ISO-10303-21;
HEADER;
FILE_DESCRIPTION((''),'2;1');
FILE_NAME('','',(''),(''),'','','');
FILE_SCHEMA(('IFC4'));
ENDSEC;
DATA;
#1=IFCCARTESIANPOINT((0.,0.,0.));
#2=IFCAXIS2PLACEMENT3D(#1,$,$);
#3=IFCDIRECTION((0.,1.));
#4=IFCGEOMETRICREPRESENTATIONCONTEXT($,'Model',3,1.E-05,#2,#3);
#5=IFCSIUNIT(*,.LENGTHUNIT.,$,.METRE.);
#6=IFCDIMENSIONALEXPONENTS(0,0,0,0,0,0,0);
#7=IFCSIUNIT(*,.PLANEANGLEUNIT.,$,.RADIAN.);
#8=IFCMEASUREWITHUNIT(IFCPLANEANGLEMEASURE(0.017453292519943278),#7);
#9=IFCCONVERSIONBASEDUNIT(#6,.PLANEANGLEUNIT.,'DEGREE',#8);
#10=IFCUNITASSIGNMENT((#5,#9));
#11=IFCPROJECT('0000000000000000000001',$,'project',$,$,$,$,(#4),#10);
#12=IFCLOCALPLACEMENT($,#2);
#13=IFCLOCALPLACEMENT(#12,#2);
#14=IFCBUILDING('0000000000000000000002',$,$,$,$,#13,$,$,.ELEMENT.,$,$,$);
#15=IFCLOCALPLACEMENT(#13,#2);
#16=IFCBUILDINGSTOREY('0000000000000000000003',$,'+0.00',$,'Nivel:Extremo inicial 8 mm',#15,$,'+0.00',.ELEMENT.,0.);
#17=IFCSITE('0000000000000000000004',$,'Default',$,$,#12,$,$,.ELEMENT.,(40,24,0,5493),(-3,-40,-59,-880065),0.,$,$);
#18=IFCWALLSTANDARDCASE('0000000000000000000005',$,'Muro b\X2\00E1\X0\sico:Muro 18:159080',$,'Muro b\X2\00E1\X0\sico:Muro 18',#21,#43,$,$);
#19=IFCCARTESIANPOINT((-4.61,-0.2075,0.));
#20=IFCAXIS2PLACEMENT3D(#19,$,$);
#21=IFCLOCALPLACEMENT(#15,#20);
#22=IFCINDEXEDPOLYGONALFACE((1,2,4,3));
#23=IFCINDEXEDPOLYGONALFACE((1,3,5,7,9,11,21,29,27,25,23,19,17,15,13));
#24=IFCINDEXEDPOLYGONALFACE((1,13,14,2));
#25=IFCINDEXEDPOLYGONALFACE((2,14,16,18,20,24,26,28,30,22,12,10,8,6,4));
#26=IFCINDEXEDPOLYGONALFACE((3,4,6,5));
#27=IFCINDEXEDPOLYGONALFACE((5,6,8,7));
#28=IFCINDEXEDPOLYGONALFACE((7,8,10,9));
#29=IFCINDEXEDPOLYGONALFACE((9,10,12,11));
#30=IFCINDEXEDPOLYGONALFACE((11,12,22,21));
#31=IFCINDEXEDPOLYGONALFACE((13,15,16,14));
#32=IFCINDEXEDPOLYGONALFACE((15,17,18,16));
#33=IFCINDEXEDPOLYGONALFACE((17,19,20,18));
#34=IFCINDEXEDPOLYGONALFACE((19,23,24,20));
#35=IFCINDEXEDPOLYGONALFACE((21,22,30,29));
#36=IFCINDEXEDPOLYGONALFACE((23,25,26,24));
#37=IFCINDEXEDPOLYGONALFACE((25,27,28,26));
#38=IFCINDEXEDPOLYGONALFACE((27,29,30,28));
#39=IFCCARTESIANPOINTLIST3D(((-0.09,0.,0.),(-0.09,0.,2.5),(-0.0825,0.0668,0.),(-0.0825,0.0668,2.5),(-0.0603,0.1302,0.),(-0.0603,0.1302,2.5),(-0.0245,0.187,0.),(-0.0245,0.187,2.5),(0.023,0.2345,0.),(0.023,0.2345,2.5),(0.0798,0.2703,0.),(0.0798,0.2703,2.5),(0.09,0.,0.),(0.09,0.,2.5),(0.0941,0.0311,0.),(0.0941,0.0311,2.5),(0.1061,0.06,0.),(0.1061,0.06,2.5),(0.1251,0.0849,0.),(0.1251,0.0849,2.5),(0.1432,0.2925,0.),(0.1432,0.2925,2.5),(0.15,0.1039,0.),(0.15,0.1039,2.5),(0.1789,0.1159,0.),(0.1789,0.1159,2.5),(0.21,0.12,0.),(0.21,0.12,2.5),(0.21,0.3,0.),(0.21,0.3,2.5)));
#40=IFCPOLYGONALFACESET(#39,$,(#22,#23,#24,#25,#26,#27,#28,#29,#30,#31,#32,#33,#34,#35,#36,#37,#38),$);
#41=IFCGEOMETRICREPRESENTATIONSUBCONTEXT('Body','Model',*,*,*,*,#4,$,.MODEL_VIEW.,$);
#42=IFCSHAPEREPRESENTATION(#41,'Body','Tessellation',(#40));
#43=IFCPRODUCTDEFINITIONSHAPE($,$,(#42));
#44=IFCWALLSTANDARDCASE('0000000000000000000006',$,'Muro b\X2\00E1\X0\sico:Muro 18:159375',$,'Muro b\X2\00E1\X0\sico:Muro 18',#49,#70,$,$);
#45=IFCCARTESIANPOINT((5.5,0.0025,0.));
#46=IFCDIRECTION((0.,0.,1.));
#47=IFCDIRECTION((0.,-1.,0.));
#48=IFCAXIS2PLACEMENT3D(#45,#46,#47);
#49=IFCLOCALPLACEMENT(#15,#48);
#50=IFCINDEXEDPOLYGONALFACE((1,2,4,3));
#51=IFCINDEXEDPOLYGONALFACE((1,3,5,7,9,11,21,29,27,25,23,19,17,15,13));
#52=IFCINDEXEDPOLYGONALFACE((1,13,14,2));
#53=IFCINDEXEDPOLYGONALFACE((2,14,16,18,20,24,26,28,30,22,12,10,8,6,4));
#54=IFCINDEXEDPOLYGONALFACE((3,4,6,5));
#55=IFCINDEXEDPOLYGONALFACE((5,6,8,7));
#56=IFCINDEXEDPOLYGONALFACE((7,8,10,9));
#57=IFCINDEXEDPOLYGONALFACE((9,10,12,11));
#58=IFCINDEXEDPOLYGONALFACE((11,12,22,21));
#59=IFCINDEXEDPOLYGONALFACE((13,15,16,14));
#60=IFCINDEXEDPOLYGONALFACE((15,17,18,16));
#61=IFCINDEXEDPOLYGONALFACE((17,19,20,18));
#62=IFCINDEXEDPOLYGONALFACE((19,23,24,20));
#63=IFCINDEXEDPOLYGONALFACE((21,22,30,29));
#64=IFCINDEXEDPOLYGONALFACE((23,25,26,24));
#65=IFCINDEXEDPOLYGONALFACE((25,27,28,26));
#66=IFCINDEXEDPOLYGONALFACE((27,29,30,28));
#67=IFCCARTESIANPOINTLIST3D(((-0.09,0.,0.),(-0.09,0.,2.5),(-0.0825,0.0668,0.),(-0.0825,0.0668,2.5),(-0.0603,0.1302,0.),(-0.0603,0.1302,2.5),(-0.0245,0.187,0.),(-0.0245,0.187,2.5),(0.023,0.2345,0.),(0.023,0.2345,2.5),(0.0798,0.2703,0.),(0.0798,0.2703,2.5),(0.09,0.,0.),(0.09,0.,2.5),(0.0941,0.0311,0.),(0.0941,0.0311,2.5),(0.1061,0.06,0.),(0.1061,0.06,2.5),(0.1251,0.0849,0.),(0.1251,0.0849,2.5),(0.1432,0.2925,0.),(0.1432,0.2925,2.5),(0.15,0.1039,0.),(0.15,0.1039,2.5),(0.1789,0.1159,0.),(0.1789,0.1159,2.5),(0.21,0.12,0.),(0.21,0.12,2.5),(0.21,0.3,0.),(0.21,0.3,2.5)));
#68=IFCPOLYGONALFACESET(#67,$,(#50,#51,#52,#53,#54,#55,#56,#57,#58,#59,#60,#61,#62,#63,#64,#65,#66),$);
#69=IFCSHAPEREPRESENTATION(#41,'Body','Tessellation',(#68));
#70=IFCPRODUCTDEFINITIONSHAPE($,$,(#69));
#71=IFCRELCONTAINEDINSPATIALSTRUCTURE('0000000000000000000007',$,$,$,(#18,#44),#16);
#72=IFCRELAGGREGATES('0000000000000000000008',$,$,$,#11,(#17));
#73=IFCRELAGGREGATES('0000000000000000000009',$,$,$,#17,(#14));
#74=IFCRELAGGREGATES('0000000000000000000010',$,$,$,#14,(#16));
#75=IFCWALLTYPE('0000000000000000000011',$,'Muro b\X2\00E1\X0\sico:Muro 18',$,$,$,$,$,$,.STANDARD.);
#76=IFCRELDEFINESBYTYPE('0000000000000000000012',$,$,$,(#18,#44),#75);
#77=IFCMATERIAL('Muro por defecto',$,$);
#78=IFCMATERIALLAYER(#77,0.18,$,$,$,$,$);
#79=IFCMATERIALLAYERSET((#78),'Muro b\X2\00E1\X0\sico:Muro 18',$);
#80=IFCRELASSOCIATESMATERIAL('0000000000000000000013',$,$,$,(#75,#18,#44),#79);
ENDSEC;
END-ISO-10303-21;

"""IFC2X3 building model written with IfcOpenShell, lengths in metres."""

from ifc_helpers import new_model, entity, si_unit, converted_unit, direction, frame, frame_2d, origin, place, context, subcontext, project, spatial, polyline, circle_curve, parameter, trimmed, segment, composite_curve, outline, extrude, material, layer, layer_set, layer_usage, type_object, element, save


model = new_model("IFC2X3")

# Units and contexts
model_context = context("Model", 3, precision=1e-05, world=origin(), true_north=direction((0.0, 1.0)))
body_context = subcontext(model_context, "Body", "Model", "MODEL_VIEW")
ifc_project = project(units=[si_unit("LENGTHUNIT", "METRE"), converted_unit("PLANEANGLEUNIT", "DEGREE", entity("IfcPlaneAngleMeasure", 0.017453292519943278), si_unit("PLANEANGLEUNIT", "RADIAN"), dimensions=[0, 0, 0, 0, 0, 0, 0])], contexts=[model_context])

# Site, building, storey
site_placement = place(None, origin())
site = spatial("IfcSite", under=ifc_project, at=site_placement, Name="Default", CompositionType="ELEMENT", RefLatitude=(40, 24, 0, 5493), RefLongitude=(-3, -40, -59, -880065), RefElevation=0.0)
building_placement = place(site_placement, origin())
building = spatial("IfcBuilding", under=site, at=building_placement, CompositionType="ELEMENT")
storey_placement = place(building_placement, origin())
storey = spatial("IfcBuildingStorey", under=building, at=storey_placement, Name="+0.00", ObjectType="Nivel:Extremo inicial 8 mm", LongName="+0.00", CompositionType="ELEMENT", Elevation=0.0)

# Shared definitions
ifc_material_1 = material(Name="Muro por defecto")
ifc_layer = layer(ifc_material_1, 0.18)
ifc_layer_set = layer_set([ifc_layer], Name="Muro básico:Muro 18")
wall_type = type_object("IfcWallType", Name="Muro básico:Muro 18", PredefinedType="STANDARD", material=ifc_layer_set)

# Walls
ifc_layer_usage_1 = layer_usage(ifc_layer_set, "AXIS2", "POSITIVE", -0.09)
wall_1_placement = place(storey_placement, frame((-4.61, -0.2075, 0.0)))
element("IfcWallStandardCase", 1, at=wall_1_placement, inside=storey, type_object=wall_type, material=ifc_layer_usage_1, Name="Muro básico:Muro 18:159080", ObjectType="Muro básico:Muro 18", context=body_context, shape_type="SweptSolid", body=[
    extrude(outline(composite_curve([segment(trimmed(circle_curve(frame_2d((0.21, 0.0), x_axis=(1.0, 0.0)), 0.3), [parameter(90.0)], [parameter(180.0)], True, "PARAMETER"), True, "CONTINUOUS"), segment(polyline([(-0.09, 0.0), (0.09, 0.0)]), True, "CONTINUOUS"), segment(trimmed(circle_curve(frame_2d((0.21, 0.0), x_axis=(1.0, 0.0)), 0.12), [parameter(90.0)], [parameter(180.0)], True, "PARAMETER"), False, "CONTINUOUS"), segment(polyline([(0.21, 0.12), (0.21, 0.3)]), True, "CONTINUOUS")], self_intersect=False)), origin(), (0.0, 0.0, 1.0), 2.5),
])
ifc_layer_usage_2 = layer_usage(ifc_layer_set, "AXIS2", "POSITIVE", -0.09)
wall_2_placement = place(storey_placement, frame((5.5, 0.0025, 0.0), z_axis=(0.0, 0.0, 1.0), x_axis=(0.0, -1.0, 0.0)))
element("IfcWallStandardCase", 2, at=wall_2_placement, inside=storey, type_object=wall_type, material=ifc_layer_usage_2, Name="Muro básico:Muro 18:159375", ObjectType="Muro básico:Muro 18", context=body_context, shape_type="SweptSolid", body=[
    extrude(outline(composite_curve([segment(trimmed(circle_curve(frame_2d((0.21, 0.0), x_axis=(1.0, 0.0)), 0.3), [parameter(90.0)], [parameter(180.0)], True, "PARAMETER"), True, "CONTINUOUS"), segment(polyline([(-0.09, 0.0), (0.09, 0.0)]), True, "CONTINUOUS"), segment(trimmed(circle_curve(frame_2d((0.21, 0.0), x_axis=(1.0, 0.0)), 0.12), [parameter(90.0)], [parameter(180.0)], True, "PARAMETER"), False, "CONTINUOUS"), segment(polyline([(0.21, 0.12), (0.21, 0.3)]), True, "CONTINUOUS")], self_intersect=False)), origin(), (0.0, 0.0, 1.0), 2.5),
])

save(model, "model.ifc")
